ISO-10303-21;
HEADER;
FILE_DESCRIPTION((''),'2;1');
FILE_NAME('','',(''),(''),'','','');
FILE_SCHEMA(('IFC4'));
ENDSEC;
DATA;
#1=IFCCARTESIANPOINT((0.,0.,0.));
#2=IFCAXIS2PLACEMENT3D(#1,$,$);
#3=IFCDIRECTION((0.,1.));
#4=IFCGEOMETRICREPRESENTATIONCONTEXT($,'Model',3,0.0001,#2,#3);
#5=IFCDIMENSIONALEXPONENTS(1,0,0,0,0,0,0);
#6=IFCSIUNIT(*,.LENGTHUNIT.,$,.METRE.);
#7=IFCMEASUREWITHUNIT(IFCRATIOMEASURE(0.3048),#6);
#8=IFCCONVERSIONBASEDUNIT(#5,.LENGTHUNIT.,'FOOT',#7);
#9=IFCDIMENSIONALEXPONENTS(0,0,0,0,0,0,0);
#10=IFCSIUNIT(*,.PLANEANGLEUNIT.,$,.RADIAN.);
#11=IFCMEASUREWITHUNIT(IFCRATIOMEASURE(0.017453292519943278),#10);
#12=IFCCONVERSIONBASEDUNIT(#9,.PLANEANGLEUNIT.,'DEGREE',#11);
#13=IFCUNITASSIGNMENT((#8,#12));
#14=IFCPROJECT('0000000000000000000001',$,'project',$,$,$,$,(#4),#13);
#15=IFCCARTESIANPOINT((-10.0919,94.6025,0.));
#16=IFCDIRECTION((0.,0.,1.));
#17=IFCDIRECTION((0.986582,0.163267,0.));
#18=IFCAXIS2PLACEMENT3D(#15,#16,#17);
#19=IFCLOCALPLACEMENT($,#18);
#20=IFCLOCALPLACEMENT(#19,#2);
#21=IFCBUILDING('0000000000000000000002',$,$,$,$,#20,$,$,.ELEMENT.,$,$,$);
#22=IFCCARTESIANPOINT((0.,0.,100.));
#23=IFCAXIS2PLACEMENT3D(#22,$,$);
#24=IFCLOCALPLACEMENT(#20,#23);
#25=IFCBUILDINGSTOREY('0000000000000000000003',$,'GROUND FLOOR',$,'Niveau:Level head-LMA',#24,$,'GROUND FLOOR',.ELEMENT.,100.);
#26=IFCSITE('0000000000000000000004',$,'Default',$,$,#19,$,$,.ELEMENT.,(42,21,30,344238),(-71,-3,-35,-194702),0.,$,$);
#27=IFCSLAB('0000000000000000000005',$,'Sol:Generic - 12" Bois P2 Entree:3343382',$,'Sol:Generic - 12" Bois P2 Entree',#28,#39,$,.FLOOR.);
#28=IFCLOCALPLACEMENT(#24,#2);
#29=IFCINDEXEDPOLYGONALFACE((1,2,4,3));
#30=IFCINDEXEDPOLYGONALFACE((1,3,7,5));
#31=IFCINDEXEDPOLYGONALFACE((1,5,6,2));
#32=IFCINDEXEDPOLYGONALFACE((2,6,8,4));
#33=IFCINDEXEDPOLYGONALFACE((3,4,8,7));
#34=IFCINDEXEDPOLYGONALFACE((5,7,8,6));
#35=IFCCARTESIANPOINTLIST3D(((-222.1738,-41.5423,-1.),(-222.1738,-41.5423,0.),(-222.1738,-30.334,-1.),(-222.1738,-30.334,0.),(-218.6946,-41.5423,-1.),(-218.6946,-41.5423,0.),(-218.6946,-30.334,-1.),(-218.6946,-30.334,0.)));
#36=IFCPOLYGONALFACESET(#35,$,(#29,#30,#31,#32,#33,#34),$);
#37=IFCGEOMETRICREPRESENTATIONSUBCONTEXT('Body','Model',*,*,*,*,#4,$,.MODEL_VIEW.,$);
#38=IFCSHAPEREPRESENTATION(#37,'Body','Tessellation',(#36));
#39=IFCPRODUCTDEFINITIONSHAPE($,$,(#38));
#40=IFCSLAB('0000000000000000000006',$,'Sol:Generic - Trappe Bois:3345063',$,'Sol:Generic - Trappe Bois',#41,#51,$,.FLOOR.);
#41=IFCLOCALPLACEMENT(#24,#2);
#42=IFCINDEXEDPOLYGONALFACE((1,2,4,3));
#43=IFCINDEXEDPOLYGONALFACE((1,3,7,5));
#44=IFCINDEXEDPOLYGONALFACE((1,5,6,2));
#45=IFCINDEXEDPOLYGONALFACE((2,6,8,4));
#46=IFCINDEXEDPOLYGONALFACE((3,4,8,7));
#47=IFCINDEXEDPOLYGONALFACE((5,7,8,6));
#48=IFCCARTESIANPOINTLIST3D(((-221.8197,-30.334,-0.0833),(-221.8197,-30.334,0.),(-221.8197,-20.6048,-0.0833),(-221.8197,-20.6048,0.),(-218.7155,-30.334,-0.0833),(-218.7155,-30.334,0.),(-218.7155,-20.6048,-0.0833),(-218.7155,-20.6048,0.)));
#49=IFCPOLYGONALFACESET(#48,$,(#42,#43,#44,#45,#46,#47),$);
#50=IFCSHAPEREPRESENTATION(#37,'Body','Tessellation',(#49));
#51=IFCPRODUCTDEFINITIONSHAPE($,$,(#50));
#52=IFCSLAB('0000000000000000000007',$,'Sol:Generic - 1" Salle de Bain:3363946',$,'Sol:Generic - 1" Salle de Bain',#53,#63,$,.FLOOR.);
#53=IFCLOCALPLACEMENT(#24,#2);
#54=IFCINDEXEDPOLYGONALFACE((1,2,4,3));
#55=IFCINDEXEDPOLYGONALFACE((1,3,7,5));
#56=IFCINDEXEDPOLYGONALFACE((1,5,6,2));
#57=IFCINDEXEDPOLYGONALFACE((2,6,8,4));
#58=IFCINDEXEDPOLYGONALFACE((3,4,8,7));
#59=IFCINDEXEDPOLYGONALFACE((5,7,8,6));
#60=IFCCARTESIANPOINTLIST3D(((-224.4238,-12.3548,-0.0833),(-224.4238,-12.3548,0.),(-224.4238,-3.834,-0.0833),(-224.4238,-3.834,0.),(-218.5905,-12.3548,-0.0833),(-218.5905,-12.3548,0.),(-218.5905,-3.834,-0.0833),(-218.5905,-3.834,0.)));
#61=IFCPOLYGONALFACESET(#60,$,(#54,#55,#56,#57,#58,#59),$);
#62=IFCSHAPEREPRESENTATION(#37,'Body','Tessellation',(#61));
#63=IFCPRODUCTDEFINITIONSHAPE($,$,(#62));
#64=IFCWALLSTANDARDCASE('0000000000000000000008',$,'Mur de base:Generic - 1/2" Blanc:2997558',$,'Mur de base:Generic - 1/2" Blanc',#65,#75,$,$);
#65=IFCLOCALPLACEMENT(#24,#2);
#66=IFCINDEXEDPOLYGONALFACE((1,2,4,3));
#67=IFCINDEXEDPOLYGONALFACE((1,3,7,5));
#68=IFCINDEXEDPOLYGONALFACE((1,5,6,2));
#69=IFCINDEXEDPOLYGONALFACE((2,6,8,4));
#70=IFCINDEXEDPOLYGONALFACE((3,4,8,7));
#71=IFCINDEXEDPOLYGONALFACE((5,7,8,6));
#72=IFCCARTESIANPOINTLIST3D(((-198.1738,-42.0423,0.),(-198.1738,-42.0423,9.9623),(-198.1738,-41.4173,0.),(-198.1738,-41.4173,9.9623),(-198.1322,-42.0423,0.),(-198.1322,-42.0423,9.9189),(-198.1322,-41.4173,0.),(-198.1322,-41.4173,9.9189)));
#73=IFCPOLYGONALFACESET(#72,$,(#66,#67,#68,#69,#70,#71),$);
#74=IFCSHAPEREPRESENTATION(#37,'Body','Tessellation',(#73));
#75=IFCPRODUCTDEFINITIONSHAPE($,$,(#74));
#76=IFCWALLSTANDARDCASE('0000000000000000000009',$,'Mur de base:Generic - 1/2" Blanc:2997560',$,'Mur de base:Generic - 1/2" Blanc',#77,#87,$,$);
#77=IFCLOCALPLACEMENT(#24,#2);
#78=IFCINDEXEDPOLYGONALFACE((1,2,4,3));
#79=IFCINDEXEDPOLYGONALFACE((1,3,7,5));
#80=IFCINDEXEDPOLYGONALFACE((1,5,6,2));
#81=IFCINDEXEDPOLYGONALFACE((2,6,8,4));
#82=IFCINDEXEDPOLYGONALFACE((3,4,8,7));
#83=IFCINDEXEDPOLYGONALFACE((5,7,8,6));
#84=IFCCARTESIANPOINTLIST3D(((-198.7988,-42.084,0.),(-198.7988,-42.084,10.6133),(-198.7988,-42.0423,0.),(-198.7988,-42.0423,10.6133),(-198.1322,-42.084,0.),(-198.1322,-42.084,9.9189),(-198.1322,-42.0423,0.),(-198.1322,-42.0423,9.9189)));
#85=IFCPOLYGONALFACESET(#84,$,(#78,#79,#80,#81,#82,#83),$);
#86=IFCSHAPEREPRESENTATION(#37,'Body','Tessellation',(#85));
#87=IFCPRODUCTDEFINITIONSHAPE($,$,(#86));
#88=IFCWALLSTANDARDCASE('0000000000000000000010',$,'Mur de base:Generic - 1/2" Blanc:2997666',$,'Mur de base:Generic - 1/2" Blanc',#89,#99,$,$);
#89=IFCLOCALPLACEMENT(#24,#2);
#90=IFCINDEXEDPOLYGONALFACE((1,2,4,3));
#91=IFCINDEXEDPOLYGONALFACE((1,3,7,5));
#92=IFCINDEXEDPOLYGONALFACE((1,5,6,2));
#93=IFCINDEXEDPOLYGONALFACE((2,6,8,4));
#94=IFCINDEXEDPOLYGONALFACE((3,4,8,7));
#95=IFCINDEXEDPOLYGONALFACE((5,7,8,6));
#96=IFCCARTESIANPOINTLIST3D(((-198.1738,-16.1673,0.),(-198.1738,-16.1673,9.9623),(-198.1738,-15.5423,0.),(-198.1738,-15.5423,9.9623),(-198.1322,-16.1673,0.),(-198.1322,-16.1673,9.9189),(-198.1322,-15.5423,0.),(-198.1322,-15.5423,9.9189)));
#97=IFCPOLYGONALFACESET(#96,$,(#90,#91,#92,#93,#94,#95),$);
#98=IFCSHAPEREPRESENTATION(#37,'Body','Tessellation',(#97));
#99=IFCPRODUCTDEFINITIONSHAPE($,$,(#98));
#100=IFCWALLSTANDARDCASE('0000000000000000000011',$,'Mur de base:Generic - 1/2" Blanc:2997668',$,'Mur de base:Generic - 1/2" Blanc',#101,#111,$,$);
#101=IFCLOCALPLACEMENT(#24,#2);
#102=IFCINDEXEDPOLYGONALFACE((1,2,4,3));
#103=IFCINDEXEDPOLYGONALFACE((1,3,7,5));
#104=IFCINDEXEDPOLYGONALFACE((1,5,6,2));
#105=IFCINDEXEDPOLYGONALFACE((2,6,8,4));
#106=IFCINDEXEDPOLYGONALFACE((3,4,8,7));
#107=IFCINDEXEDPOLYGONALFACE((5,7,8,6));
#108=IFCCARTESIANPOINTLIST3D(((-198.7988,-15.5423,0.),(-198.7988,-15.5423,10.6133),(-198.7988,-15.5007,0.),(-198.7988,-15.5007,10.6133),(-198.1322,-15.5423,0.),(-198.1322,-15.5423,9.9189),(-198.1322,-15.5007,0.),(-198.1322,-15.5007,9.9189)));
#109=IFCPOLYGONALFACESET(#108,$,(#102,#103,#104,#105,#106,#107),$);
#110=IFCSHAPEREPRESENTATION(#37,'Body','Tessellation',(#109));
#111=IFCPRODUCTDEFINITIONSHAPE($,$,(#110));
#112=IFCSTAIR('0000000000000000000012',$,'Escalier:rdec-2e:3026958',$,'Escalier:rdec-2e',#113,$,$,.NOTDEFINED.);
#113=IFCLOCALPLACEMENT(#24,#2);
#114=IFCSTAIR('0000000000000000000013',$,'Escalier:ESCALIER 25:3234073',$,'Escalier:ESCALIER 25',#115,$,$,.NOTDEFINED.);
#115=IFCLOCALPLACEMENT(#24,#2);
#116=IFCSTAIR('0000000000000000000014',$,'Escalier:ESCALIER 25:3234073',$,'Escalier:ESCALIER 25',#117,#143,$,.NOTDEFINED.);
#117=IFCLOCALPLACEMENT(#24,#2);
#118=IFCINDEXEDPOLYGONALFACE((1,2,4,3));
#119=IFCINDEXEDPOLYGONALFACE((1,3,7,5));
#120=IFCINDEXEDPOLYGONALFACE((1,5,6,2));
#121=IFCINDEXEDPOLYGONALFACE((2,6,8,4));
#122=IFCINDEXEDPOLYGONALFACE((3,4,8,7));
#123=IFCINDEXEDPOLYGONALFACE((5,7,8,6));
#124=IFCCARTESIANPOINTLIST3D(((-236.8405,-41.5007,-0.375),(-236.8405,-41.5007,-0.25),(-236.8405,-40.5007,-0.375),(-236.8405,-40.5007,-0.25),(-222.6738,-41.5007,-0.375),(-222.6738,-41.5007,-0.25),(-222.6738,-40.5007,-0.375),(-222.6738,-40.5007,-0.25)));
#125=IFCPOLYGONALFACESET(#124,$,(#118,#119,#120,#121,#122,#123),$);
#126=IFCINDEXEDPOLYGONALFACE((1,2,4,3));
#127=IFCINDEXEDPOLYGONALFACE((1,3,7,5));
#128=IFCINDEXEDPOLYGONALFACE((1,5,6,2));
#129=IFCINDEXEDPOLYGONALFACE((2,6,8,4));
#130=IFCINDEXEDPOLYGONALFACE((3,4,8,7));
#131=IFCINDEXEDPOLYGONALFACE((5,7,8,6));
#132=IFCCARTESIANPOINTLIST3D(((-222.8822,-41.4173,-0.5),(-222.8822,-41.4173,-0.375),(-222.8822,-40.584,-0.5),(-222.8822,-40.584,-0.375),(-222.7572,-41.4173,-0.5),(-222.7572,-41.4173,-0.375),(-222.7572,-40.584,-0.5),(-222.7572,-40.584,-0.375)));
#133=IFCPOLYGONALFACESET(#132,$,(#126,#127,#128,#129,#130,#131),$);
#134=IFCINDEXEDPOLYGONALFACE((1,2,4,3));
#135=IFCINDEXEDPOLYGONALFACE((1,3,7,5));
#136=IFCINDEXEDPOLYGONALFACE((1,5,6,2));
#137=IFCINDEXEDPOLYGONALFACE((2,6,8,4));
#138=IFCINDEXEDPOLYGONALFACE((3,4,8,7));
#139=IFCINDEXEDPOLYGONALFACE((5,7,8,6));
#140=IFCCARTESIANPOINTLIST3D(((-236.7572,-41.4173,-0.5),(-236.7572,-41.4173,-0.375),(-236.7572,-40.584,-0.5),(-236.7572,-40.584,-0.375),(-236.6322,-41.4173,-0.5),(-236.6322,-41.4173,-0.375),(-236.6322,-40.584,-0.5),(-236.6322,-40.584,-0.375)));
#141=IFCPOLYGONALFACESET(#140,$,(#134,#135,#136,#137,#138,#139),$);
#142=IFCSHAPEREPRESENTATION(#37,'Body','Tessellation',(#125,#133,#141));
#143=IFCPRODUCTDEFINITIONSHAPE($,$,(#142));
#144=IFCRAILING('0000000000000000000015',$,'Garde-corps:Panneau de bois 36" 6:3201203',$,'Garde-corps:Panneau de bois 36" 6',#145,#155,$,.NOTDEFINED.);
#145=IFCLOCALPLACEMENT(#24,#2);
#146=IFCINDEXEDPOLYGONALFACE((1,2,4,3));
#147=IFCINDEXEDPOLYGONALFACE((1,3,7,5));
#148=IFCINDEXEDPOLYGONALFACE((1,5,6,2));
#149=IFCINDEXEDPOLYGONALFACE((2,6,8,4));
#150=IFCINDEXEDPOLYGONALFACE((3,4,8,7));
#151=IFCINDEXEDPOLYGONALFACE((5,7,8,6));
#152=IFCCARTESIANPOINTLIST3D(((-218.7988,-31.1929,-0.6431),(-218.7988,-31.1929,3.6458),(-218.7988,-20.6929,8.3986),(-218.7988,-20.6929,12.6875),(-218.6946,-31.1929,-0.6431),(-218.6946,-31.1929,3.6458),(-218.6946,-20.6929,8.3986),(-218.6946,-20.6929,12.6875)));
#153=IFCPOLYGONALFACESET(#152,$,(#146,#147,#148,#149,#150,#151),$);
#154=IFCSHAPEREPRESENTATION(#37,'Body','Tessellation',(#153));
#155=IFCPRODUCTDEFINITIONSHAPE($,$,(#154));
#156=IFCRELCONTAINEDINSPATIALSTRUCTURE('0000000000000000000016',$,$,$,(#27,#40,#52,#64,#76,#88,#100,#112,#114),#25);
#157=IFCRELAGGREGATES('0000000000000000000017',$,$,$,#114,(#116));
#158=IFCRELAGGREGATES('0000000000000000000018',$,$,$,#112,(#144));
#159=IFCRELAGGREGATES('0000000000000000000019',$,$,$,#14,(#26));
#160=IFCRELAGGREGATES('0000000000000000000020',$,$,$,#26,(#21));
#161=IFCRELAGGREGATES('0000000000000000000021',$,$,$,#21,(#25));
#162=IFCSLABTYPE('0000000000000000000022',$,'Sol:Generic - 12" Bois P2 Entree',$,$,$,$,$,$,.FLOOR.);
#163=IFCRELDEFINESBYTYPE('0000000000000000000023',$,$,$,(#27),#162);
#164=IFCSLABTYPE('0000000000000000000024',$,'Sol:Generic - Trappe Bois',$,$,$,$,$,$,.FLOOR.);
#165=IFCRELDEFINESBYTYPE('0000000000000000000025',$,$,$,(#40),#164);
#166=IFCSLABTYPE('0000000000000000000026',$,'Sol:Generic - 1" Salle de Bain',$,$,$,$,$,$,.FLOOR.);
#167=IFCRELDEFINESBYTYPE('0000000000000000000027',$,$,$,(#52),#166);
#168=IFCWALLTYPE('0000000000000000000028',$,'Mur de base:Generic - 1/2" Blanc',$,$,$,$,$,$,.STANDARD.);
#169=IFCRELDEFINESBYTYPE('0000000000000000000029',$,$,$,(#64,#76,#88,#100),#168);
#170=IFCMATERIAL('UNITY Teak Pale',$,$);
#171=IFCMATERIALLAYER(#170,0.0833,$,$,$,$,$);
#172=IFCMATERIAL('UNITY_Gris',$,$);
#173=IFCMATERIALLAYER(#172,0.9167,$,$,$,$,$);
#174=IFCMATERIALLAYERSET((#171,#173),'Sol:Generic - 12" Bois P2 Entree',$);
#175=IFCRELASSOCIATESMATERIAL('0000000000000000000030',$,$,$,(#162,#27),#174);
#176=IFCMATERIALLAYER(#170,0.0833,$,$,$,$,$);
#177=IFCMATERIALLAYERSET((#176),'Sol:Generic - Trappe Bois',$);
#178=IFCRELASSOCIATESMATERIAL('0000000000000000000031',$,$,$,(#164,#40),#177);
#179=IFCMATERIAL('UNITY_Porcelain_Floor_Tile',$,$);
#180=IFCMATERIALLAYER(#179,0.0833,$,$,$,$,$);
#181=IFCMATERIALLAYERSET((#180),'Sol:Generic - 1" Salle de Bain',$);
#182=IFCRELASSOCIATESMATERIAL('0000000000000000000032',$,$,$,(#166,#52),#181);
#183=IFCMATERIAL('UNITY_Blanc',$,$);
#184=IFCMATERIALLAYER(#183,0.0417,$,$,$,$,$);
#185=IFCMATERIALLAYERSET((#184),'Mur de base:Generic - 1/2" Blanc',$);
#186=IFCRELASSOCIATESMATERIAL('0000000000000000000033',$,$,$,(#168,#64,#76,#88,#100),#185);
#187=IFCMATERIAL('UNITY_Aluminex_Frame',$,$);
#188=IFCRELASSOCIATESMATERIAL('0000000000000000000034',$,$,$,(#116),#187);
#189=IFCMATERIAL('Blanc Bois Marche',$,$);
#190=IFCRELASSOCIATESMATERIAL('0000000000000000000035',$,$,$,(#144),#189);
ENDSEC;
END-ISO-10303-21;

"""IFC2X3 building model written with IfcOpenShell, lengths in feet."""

from ifc_helpers import new_model, entity, si_unit, converted_unit, direction, frame, frame_2d, origin, place, context, subcontext, project, spatial, polyline, rectangle, outline, extrude, clip, bounded_halfspace, material, layer, layer_set, layer_usage, type_object, element, aggregate, save


model = new_model("IFC2X3")

# Units and contexts
model_context = context("Model", 3, precision=0.0001, world=origin(), true_north=direction((0.0, 1.0)))
body_context = subcontext(model_context, "Body", "Model", "MODEL_VIEW")
ifc_project = project(units=[converted_unit("LENGTHUNIT", "FOOT", entity("IfcRatioMeasure", 0.3048), si_unit("LENGTHUNIT", "METRE"), dimensions=[1, 0, 0, 0, 0, 0, 0]), converted_unit("PLANEANGLEUNIT", "DEGREE", entity("IfcRatioMeasure", 0.017453292519943278), si_unit("PLANEANGLEUNIT", "RADIAN"), dimensions=[0, 0, 0, 0, 0, 0, 0])], contexts=[model_context])

# Site, building, storey
site_placement = place(None, frame((-10.0919, 94.6025, 0.0), z_axis=(0.0, 0.0, 1.0), x_axis=(0.986582, 0.163267, 0.0)))
site = spatial("IfcSite", under=ifc_project, at=site_placement, Name="Default", CompositionType="ELEMENT", RefLatitude=(42, 21, 30, 344238), RefLongitude=(-71, -3, -35, -194702), RefElevation=0.0)
building_placement = place(site_placement, origin())
building = spatial("IfcBuilding", under=site, at=building_placement, CompositionType="ELEMENT")
storey_placement = place(building_placement, frame((0.0, 0.0, 100.0)))
storey = spatial("IfcBuildingStorey", under=building, at=storey_placement, Name="GROUND FLOOR", ObjectType="Niveau:Level head-LMA", LongName="GROUND FLOOR", CompositionType="ELEMENT", Elevation=100.0)

# Slabs
ifc_material_1 = material(Name="UNITY_Gris")
ifc_material_2 = material(Name="UNITY Teak Pale")
ifc_layer_1 = layer(ifc_material_2, 0.0833)
ifc_layer_2 = layer(ifc_material_1, 0.9167)
ifc_layer_set_1 = layer_set([ifc_layer_1, ifc_layer_2], Name="Sol:Generic - 12\" Bois P2 Entree")
ifc_layer_usage_1 = layer_usage(ifc_layer_set_1, "AXIS3", "POSITIVE", 0.0)
slab_type_1 = type_object("IfcSlabType", Name="Sol:Generic - 12\" Bois P2 Entree", PredefinedType="FLOOR", material=ifc_layer_set_1)
slab_1_placement = place(storey_placement, origin())
element("IfcSlab", 1, at=slab_1_placement, inside=storey, type_object=slab_type_1, material=ifc_layer_usage_1, Name="Sol:Generic - 12\" Bois P2 Entree:3343382", ObjectType="Sol:Generic - 12\" Bois P2 Entree", PredefinedType="FLOOR", context=body_context, shape_type="SweptSolid", body=[
    extrude(rectangle(XDim=11.2083, YDim=3.4792, at=frame_2d((0.0, 0.0), x_axis=(1.0, 0.0))), frame((-220.4342, -35.9382, 0.0), z_axis=(0.0, 0.0, -1.0), x_axis=(0.0, 1.0, 0.0)), (0.0, 0.0, 1.0), 1.0),
])
ifc_layer_3 = layer(ifc_material_2, 0.0833)
ifc_layer_set_2 = layer_set([ifc_layer_3], Name="Sol:Generic - Trappe Bois")
ifc_layer_usage_2 = layer_usage(ifc_layer_set_2, "AXIS3", "POSITIVE", 0.0)
slab_type_2 = type_object("IfcSlabType", Name="Sol:Generic - Trappe Bois", PredefinedType="FLOOR", material=ifc_layer_set_2)
slab_2_placement = place(storey_placement, origin())
element("IfcSlab", 2, at=slab_2_placement, inside=storey, type_object=slab_type_2, material=ifc_layer_usage_2, Name="Sol:Generic - Trappe Bois:3345063", ObjectType="Sol:Generic - Trappe Bois", PredefinedType="FLOOR", context=body_context, shape_type="SweptSolid", body=[
    extrude(rectangle(XDim=9.7292, YDim=3.1042, at=frame_2d((0.0, 0.0), x_axis=(1.0, 0.0))), frame((-220.2676, -25.4694, 0.0), z_axis=(0.0, 0.0, -1.0), x_axis=(0.0, 1.0, 0.0)), (0.0, 0.0, 1.0), 0.0833),
])
ifc_material_3 = material(Name="UNITY_Porcelain_Floor_Tile")
ifc_layer_4 = layer(ifc_material_3, 0.0833)
ifc_layer_set_3 = layer_set([ifc_layer_4], Name="Sol:Generic - 1\" Salle de Bain")
ifc_layer_usage_3 = layer_usage(ifc_layer_set_3, "AXIS3", "POSITIVE", 0.0)
slab_type_3 = type_object("IfcSlabType", Name="Sol:Generic - 1\" Salle de Bain", PredefinedType="FLOOR", material=ifc_layer_set_3)
slab_3_placement = place(storey_placement, origin())
element("IfcSlab", 3, at=slab_3_placement, inside=storey, type_object=slab_type_3, material=ifc_layer_usage_3, Name="Sol:Generic - 1\" Salle de Bain:3363946", ObjectType="Sol:Generic - 1\" Salle de Bain", PredefinedType="FLOOR", context=body_context, shape_type="SweptSolid", body=[
    extrude(rectangle(XDim=8.5208, YDim=5.8333, at=frame_2d((0.0, 0.0), x_axis=(1.0, 0.0))), frame((-221.5072, -8.0944, 0.0), z_axis=(0.0, 0.0, -1.0), x_axis=(0.0, 1.0, 0.0)), (0.0, 0.0, 1.0), 0.0833),
])

# Shared definitions
ifc_material_4 = material(Name="UNITY_Aluminex_Frame")

# Walls
ifc_material_5 = material(Name="UNITY_Blanc")
ifc_layer_5 = layer(ifc_material_5, 0.0417)
ifc_layer_set_4 = layer_set([ifc_layer_5], Name="Mur de base:Generic - 1/2\" Blanc")
ifc_layer_usage_4 = layer_usage(ifc_layer_set_4, "AXIS2", "NEGATIVE", 0.0208)
wall_type_1 = type_object("IfcWallType", Name="Mur de base:Generic - 1/2\" Blanc", PredefinedType="STANDARD", material=ifc_layer_set_4)
wall_1_placement = place(storey_placement, frame((-198.153, -41.4173, 0.0), z_axis=(0.0, 0.0, 1.0), x_axis=(0.0, -1.0, 0.0)))
element("IfcWallStandardCase", 4, at=wall_1_placement, inside=storey, type_object=wall_type_1, material=ifc_layer_usage_4, Name="Mur de base:Generic - 1/2\" Blanc:2997558", ObjectType="Mur de base:Generic - 1/2\" Blanc", context=body_context, shape_type="Clipping", body=[
    clip(extrude(rectangle(XDim=0.625, YDim=0.0417, at=frame_2d((0.3125, 0.0), x_axis=(-1.0, 0.0))), origin(), (0.0, 0.0, 1.0), 9.9623), bounded_halfspace(frame((0.0, -0.0208, 9.9623), z_axis=(0.0, 0.721387, 0.692532), x_axis=(-1.0, 0.0, 0.0)), False, frame((0.0, -0.0208, 9.9623)), polyline([(0.0, 0.0), (0.625, 0.0), (0.625, 0.0417), (0.0, 0.0417), (0.0, 0.0)]))),
])
ifc_layer_usage_5 = layer_usage(ifc_layer_set_4, "AXIS2", "NEGATIVE", 0.0208)
wall_2_placement = place(storey_placement, frame((-198.1322, -42.0632, 0.0), z_axis=(0.0, 0.0, 1.0), x_axis=(-1.0, 0.0, 0.0)))
element("IfcWallStandardCase", 5, at=wall_2_placement, inside=storey, type_object=wall_type_1, material=ifc_layer_usage_5, Name="Mur de base:Generic - 1/2\" Blanc:2997560", ObjectType="Mur de base:Generic - 1/2\" Blanc", context=body_context, shape_type="Clipping", body=[
    clip(extrude(rectangle(XDim=0.6667, YDim=0.0417, at=frame_2d((0.3333, 0.0), x_axis=(-1.0, 0.0))), origin(), (0.0, 0.0, 1.0), 10.6133), bounded_halfspace(frame((0.0, -0.0208, 9.9189), z_axis=(-0.721387, 0.0, 0.692532), x_axis=(0.0, -1.0, 0.0)), False, frame((0.0, -0.0208, 9.9189)), polyline([(0.0, 0.0), (0.0417, 0.0), (0.6667, 0.0), (0.6667, 0.0417), (0.0, 0.0417), (0.0, 0.0)]))),
])
ifc_layer_usage_6 = layer_usage(ifc_layer_set_4, "AXIS2", "POSITIVE", -0.0208)
wall_3_placement = place(storey_placement, frame((-198.153, -16.1673, 0.0), z_axis=(0.0, 0.0, 1.0), x_axis=(0.0, 1.0, 0.0)))
element("IfcWallStandardCase", 6, at=wall_3_placement, inside=storey, type_object=wall_type_1, material=ifc_layer_usage_6, Name="Mur de base:Generic - 1/2\" Blanc:2997666", ObjectType="Mur de base:Generic - 1/2\" Blanc", context=body_context, shape_type="Clipping", body=[
    clip(extrude(rectangle(XDim=0.625, YDim=0.0417, at=frame_2d((0.3125, 0.0), x_axis=(-1.0, 0.0))), origin(), (0.0, 0.0, 1.0), 9.9623), bounded_halfspace(frame((0.0, -0.0208, 9.9189), z_axis=(0.0, -0.721387, 0.692532), x_axis=(1.0, 0.0, 0.0)), False, frame((0.0, -0.0208, 9.9189)), polyline([(0.0, 0.0), (0.625, 0.0), (0.625, 0.0417), (0.0, 0.0417), (0.0, 0.0)]))),
])
ifc_layer_usage_7 = layer_usage(ifc_layer_set_4, "AXIS2", "POSITIVE", -0.0208)
wall_4_placement = place(storey_placement, frame((-198.1322, -15.5215, 0.0), z_axis=(0.0, 0.0, 1.0), x_axis=(-1.0, 0.0, 0.0)))
element("IfcWallStandardCase", 7, at=wall_4_placement, inside=storey, type_object=wall_type_1, material=ifc_layer_usage_7, Name="Mur de base:Generic - 1/2\" Blanc:2997668", ObjectType="Mur de base:Generic - 1/2\" Blanc", context=body_context, shape_type="Clipping", body=[
    clip(extrude(rectangle(XDim=0.6667, YDim=0.0417, at=frame_2d((0.3333, 0.0), x_axis=(-1.0, 0.0))), origin(), (0.0, 0.0, 1.0), 10.6133), bounded_halfspace(frame((0.0, -0.0208, 9.9189), z_axis=(-0.721387, 0.0, 0.692532), x_axis=(0.0, -1.0, 0.0)), False, frame((0.0, -0.0208, 9.9189)), polyline([(0.0, 0.0), (0.6667, 0.0), (0.6667, 0.0417), (0.0417, 0.0417), (0.0, 0.0417), (0.0, 0.0)]))),
])

# Stairs
stair_1_placement = place(storey_placement, origin())
stair_1 = element("IfcStair", 8, at=stair_1_placement, inside=storey, Name="Escalier:rdec-2e:3026958", ObjectType="Escalier:rdec-2e", ShapeType="NOTDEFINED")
stair_2_placement = place(storey_placement, origin())
stair_2 = element("IfcStair", 9, at=stair_2_placement, inside=storey, Name="Escalier:ESCALIER 25:3234073", ObjectType="Escalier:ESCALIER 25", ShapeType="NOTDEFINED")
stair_3_placement = place(stair_2_placement, origin())
stair_3 = element("IfcStair", 10, at=stair_3_placement, material=ifc_material_4, Name="Escalier:ESCALIER 25:3234073", ObjectType="Escalier:ESCALIER 25", ShapeType="NOTDEFINED", context=body_context, shape_type="SweptSolid", body=[
    extrude(rectangle(XDim=1.0, YDim=14.1667, at=frame_2d((0.0, 0.0), x_axis=(1.0, 0.0))), frame((-229.7572, -41.0007, -0.375), z_axis=(0.0, 0.0, 1.0), x_axis=(0.0, -1.0, 0.0)), (0.0, 0.0, 1.0), 0.125),
    extrude(rectangle(XDim=0.8333, YDim=0.125, at=frame_2d((0.0, 0.0), x_axis=(1.0, 0.0))), frame((-222.8197, -41.0007, -0.5), z_axis=(0.0, 0.0, 1.0), x_axis=(0.0, -1.0, 0.0)), (0.0, 0.0, 1.0), 0.125),
    extrude(rectangle(XDim=0.8333, YDim=0.125, at=frame_2d((0.0, 0.0), x_axis=(1.0, 0.0))), frame((-236.6947, -41.0007, -0.5), z_axis=(0.0, 0.0, 1.0), x_axis=(0.0, -1.0, 0.0)), (0.0, 0.0, 1.0), 0.125),
])
aggregate(stair_2, [stair_3])

# Railing
ifc_material_6 = material(Name="Blanc Bois Marche")
railing_placement = place(stair_1_placement, frame((0.0, 0.0, 9.3333)))
railing = element("IfcRailing", 11, at=railing_placement, material=ifc_material_6, Name="Garde-corps:Panneau de bois 36\" 6:3201203", ObjectType="Garde-corps:Panneau de bois 36\" 6", PredefinedType="NOTDEFINED", context=body_context, shape_type="SweptSolid", body=[
    extrude(outline(polyline([(-8.3275, -1.625), (5.5289, -1.625), (8.3275, 1.625), (-5.5289, 1.625), (-8.3275, -1.625)])), frame((-218.7988, -25.9429, -3.3111), z_axis=(1.0, 0.0, 0.0), x_axis=(0.0, -0.757769, -0.652523)), (0.0, 0.0, 1.0), 0.1042),
])
aggregate(stair_1, [railing])

save(model, "model.ifc")
